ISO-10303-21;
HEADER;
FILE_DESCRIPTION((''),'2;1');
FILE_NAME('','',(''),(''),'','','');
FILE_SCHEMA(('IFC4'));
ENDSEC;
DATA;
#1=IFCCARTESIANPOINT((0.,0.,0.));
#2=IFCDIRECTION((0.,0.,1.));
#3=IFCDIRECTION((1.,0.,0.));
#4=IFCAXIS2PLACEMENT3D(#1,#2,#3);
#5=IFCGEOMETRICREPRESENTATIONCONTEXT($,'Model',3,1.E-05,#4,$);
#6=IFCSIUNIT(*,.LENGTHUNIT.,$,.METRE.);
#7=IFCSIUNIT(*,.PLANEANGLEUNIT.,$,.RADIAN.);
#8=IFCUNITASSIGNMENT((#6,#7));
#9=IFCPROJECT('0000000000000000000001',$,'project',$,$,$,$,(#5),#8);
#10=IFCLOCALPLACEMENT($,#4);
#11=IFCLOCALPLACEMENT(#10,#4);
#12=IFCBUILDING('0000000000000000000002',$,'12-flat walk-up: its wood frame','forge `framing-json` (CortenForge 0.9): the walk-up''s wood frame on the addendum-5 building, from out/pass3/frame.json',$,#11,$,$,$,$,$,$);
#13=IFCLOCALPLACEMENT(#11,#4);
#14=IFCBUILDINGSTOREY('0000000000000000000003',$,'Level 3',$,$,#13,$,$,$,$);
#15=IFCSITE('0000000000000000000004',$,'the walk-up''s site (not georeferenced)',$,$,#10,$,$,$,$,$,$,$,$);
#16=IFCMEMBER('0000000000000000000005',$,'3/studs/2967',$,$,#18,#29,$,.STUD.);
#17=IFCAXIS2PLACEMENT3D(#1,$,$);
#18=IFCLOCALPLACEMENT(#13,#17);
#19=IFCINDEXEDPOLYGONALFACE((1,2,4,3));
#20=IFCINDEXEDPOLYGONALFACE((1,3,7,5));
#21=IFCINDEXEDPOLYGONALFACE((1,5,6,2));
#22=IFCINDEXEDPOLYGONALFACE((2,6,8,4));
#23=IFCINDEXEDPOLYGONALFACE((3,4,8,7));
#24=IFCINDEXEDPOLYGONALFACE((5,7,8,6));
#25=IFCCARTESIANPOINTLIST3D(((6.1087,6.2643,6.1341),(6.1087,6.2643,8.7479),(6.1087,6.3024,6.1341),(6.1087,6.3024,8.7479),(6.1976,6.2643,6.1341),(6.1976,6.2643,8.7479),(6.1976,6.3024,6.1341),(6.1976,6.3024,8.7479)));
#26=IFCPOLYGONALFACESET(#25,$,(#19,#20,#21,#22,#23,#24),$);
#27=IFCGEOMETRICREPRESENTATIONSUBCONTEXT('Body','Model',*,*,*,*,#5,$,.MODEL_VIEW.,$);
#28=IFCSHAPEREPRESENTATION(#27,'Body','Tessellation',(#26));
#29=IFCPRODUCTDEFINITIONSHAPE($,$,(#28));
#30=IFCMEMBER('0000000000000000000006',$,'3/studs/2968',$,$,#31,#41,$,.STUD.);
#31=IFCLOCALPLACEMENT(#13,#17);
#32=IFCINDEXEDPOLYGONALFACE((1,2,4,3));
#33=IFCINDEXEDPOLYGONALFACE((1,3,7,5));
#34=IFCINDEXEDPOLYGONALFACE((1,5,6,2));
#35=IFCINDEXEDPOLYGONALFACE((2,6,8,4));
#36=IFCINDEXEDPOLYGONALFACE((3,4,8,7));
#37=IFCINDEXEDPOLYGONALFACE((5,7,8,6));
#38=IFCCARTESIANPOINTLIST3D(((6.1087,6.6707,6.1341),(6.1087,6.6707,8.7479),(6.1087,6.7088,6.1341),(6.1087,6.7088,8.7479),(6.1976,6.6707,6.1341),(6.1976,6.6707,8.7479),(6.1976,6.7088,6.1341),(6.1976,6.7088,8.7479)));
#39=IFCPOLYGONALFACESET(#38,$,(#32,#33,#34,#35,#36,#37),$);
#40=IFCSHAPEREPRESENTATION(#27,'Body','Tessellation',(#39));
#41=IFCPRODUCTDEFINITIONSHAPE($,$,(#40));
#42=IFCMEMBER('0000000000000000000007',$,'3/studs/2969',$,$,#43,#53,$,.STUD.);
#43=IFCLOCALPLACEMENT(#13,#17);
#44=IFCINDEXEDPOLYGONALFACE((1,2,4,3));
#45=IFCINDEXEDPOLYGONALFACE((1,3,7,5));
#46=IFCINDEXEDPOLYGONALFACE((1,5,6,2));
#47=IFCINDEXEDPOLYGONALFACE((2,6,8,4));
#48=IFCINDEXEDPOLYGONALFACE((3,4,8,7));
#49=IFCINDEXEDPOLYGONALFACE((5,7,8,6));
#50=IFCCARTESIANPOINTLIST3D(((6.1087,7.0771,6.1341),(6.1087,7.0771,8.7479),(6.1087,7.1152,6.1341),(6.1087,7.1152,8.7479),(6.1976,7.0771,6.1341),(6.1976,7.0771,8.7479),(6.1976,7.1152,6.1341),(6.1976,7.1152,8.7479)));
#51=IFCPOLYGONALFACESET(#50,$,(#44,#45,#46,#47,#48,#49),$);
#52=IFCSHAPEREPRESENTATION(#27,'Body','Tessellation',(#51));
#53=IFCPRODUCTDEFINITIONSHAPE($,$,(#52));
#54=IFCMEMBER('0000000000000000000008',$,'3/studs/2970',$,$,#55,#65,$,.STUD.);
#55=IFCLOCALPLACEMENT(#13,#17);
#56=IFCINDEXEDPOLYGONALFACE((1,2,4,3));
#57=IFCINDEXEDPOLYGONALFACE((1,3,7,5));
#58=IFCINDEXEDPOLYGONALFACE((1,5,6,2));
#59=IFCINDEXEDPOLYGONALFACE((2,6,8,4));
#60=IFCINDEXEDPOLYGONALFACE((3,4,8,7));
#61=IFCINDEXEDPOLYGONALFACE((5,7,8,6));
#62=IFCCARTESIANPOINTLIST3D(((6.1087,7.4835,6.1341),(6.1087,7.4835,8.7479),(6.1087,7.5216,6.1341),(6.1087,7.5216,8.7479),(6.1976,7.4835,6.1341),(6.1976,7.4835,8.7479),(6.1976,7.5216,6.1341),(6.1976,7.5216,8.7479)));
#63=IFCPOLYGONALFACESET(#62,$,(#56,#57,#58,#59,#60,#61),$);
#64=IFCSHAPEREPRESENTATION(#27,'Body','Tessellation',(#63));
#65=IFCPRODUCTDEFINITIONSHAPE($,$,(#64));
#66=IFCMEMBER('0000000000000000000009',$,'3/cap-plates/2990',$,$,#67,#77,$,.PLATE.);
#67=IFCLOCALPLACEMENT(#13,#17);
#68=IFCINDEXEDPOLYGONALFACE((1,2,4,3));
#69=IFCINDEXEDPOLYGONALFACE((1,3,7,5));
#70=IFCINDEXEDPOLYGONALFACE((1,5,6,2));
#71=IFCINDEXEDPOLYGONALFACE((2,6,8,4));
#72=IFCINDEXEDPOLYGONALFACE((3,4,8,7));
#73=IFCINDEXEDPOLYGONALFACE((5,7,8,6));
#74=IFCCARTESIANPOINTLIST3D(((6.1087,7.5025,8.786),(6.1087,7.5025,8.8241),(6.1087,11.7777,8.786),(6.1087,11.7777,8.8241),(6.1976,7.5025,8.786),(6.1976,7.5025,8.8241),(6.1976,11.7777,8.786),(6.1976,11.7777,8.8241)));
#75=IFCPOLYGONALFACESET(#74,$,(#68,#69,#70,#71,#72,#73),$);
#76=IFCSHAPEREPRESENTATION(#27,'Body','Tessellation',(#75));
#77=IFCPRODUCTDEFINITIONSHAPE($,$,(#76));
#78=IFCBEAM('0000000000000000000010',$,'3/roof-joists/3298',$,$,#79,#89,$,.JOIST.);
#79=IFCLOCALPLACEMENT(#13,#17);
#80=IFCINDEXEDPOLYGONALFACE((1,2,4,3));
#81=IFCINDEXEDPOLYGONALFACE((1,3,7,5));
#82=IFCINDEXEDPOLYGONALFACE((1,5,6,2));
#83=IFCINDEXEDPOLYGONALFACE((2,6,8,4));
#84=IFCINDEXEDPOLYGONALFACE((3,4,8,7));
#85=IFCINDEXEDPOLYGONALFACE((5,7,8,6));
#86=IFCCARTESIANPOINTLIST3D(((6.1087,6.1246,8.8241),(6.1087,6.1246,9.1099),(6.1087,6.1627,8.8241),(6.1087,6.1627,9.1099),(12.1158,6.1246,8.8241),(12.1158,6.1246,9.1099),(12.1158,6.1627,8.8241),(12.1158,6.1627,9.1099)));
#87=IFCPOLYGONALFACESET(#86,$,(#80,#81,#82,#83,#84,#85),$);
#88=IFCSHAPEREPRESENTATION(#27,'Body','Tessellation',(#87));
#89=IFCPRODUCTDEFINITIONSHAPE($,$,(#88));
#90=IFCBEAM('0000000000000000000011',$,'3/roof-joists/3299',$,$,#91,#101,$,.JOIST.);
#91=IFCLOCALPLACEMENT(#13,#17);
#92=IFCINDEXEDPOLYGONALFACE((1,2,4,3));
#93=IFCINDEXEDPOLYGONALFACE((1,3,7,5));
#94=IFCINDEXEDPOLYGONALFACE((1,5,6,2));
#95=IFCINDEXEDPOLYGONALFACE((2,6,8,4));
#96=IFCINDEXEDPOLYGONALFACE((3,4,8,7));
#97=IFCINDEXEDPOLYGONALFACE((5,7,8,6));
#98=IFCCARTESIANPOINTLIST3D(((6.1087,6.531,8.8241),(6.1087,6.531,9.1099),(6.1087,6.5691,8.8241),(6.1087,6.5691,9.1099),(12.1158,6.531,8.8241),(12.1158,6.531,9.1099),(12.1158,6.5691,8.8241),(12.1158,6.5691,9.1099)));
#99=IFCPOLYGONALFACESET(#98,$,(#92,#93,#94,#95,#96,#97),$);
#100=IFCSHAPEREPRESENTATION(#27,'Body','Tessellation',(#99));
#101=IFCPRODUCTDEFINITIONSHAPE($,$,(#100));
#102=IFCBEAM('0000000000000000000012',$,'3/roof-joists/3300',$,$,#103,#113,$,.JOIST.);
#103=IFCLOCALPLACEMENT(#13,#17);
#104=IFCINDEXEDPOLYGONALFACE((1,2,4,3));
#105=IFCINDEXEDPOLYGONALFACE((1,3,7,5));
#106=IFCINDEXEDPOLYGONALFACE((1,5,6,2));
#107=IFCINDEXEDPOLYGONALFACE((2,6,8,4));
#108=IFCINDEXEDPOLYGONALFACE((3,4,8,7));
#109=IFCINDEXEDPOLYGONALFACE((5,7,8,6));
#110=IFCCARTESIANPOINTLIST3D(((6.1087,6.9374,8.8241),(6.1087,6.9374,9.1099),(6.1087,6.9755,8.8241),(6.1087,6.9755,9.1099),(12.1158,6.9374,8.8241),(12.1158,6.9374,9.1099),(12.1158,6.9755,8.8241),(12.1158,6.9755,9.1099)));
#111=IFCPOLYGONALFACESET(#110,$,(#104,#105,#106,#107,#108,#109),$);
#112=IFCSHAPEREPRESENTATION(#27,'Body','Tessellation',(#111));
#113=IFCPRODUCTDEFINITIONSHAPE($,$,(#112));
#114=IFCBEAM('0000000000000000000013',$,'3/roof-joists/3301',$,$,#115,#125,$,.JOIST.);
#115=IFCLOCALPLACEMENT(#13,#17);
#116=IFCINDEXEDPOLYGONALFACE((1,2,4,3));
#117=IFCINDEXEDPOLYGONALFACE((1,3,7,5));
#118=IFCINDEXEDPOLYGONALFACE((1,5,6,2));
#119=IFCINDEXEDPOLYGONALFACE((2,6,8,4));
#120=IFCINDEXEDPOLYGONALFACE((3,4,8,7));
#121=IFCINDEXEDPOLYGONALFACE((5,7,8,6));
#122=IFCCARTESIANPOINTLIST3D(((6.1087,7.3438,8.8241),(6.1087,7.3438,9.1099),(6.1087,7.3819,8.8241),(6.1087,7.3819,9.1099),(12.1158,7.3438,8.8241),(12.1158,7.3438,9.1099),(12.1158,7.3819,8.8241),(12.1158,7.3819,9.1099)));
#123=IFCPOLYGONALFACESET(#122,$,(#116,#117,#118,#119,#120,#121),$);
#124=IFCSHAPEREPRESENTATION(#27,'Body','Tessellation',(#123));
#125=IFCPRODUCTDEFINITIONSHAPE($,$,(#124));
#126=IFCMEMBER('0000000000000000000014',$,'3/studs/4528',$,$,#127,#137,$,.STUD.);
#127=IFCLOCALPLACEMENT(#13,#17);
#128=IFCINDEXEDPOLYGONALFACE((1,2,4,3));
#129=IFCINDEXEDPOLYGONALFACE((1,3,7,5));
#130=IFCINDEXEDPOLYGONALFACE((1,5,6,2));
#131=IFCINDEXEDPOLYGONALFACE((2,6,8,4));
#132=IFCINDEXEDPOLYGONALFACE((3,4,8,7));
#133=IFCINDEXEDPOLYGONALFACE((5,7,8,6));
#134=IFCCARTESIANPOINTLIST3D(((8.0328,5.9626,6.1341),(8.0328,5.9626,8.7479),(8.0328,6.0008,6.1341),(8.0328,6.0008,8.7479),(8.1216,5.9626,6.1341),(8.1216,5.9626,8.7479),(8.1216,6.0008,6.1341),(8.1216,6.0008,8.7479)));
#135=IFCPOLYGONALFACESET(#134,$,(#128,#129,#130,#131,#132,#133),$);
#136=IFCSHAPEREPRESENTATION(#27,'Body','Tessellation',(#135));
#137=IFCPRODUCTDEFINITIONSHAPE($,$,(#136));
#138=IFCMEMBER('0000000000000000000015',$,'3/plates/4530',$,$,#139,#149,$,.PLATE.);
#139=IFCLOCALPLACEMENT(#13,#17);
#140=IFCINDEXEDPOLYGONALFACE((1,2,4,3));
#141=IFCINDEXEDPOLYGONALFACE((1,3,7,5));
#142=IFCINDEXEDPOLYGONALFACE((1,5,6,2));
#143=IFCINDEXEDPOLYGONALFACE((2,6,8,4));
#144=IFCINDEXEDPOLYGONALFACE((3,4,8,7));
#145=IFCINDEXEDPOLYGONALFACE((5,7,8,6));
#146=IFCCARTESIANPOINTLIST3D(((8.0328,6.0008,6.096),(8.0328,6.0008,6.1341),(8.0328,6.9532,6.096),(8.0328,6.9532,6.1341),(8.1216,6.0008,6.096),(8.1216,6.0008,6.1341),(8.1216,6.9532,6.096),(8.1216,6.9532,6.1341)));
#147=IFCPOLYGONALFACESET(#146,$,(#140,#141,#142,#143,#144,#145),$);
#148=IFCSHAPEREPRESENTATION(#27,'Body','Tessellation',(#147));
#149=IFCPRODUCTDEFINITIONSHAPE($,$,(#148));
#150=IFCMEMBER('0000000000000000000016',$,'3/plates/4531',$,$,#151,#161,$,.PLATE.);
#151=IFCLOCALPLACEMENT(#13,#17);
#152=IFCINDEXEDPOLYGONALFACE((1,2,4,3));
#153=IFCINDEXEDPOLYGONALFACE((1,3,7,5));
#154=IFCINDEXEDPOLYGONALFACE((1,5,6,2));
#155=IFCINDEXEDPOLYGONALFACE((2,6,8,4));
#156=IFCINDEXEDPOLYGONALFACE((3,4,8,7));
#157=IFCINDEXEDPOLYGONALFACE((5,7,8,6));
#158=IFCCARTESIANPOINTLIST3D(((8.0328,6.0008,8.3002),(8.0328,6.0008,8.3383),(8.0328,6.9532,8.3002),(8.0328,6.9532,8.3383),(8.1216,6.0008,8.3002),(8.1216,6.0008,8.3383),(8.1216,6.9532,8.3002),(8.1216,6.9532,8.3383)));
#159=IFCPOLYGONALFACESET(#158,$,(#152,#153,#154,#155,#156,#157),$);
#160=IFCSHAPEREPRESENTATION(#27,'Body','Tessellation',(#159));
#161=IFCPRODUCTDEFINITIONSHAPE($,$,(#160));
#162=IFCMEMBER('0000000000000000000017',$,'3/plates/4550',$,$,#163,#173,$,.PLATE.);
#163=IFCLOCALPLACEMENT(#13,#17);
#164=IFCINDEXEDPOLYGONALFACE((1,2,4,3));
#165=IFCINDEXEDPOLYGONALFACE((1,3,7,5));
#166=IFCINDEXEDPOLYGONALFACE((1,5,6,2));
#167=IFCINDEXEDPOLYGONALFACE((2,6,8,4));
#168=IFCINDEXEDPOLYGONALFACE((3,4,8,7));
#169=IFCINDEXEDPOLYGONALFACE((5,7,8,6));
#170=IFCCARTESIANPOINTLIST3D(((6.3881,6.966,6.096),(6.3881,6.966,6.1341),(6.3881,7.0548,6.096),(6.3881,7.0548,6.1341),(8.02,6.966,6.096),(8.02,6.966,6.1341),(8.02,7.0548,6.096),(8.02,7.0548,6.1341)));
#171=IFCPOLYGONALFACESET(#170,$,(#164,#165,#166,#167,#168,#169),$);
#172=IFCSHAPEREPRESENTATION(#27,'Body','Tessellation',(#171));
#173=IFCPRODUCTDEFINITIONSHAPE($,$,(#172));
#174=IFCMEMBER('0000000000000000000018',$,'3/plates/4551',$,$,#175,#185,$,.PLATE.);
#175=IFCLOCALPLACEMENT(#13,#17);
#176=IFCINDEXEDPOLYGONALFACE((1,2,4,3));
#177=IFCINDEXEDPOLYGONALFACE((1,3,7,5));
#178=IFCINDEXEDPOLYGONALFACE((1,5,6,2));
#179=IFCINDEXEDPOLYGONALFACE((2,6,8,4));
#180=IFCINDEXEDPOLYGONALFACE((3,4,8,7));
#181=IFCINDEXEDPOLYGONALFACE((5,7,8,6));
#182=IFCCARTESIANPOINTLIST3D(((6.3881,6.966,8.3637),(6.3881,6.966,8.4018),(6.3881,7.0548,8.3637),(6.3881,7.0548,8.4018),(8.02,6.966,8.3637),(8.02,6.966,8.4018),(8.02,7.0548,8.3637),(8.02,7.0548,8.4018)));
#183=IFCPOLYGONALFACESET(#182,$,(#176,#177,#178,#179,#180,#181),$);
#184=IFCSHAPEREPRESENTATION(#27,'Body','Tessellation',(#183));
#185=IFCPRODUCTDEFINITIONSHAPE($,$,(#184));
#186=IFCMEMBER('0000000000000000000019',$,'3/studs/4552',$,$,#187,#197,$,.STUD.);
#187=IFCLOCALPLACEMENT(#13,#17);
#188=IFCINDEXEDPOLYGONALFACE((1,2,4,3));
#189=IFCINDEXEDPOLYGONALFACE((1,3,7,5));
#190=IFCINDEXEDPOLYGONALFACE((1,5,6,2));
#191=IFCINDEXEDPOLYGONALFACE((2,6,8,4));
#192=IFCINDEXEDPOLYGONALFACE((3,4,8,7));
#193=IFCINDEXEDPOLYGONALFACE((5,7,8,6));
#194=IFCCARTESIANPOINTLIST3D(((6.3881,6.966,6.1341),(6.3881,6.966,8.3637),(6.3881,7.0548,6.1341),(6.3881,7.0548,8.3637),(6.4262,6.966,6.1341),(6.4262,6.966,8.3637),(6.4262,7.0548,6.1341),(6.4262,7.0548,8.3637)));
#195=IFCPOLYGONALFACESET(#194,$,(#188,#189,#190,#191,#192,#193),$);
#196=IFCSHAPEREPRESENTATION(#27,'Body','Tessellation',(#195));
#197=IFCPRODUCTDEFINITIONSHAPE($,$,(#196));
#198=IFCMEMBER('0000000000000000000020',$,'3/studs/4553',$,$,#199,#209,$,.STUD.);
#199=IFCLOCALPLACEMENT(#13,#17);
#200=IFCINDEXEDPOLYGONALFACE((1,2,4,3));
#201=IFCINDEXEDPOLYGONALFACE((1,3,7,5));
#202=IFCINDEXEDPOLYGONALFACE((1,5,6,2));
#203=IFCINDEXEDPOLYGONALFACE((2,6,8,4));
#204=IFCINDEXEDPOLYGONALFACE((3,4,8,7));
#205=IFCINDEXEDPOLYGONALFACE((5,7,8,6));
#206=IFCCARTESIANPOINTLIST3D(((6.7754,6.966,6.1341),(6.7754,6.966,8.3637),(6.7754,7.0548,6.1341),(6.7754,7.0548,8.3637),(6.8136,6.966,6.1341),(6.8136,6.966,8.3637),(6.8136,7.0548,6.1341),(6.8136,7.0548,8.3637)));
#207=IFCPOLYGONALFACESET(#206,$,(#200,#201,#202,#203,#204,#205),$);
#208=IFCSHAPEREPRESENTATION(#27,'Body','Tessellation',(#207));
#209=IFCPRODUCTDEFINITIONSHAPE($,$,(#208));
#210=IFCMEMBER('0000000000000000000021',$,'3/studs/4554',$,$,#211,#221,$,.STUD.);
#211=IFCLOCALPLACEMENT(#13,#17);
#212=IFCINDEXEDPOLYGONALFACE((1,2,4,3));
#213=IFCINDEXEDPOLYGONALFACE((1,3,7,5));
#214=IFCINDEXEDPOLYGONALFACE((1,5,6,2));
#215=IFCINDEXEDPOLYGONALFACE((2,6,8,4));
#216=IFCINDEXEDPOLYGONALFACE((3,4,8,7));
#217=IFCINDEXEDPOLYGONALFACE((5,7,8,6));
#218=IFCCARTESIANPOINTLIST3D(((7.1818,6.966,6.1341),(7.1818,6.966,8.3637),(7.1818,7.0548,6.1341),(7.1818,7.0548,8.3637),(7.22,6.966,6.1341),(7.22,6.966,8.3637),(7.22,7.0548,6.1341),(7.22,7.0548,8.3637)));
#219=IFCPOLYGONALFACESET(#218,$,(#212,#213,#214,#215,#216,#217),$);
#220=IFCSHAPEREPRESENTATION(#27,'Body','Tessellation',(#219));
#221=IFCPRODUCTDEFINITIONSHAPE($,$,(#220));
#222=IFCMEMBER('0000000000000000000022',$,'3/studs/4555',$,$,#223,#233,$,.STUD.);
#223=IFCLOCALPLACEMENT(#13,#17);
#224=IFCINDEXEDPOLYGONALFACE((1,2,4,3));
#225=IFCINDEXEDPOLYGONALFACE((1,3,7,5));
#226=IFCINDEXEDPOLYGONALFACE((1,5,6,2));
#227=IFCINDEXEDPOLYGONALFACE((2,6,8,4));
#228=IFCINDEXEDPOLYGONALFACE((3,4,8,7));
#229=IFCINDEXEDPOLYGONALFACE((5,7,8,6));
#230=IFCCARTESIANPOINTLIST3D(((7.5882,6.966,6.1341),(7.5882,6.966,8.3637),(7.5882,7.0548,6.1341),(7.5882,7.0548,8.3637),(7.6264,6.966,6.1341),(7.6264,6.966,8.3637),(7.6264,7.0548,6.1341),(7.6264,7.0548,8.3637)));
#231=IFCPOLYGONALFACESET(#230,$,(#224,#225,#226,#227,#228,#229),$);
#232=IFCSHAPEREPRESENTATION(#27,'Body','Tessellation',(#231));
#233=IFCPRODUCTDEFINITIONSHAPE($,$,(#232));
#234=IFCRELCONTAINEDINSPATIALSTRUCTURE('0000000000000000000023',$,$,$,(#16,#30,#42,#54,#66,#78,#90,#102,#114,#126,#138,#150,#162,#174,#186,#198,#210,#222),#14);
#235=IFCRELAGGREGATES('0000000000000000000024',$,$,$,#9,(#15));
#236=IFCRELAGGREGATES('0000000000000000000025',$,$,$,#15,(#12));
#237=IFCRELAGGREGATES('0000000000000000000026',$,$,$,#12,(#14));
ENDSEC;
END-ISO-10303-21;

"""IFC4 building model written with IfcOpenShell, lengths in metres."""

from ifc_helpers import new_model, si_unit, frame, frame_2d, origin, origin_with_axes, place, context, subcontext, project, spatial, rectangle, extrude, element, save


model = new_model("IFC4")

# Units and contexts
model_context = context("Model", 3, precision=1e-05, world=origin_with_axes())
body_context = subcontext(model_context, "Body", "Model", "MODEL_VIEW")
ifc_project = project(units=[si_unit("LENGTHUNIT", "METRE"), si_unit("PLANEANGLEUNIT", "RADIAN")], contexts=[model_context])

# Site, building, storey
site_placement = place(None, origin_with_axes())
site = spatial("IfcSite", under=ifc_project, at=site_placement, Name="the walk-up's site (not georeferenced)")
building_placement = place(site_placement, origin_with_axes())
building = spatial("IfcBuilding", under=site, at=building_placement, Name="12-flat walk-up: its wood frame", Description="forge `framing-json` (CortenForge 0.9): the walk-up's wood frame on the addendum-5 building, from out/pass3/frame.json")
storey_placement = place(building_placement, origin_with_axes())
storey = spatial("IfcBuildingStorey", under=building, at=storey_placement, Name="Level 3")

# Members
for number, where, z_axis, x_axis, name in (
    (1, (6.1087, 6.2643, 6.1341), (0.0, 0.0, 1.0), (1.0, 0.0, 0.0), "3/studs/2967"),
    (2, (6.1087, 6.6707, 6.1341), (0.0, 0.0, 1.0), (1.0, 0.0, 0.0), "3/studs/2968"),
    (3, (6.1087, 7.0771, 6.1341), (0.0, 0.0, 1.0), (1.0, 0.0, 0.0), "3/studs/2969"),
    (4, (6.1087, 7.4835, 6.1341), (0.0, 0.0, 1.0), (1.0, 0.0, 0.0), "3/studs/2970"),
):
    element("IfcMember", number, at=place(storey_placement, frame(where, z_axis=z_axis, x_axis=x_axis)), inside=storey, Name=name, PredefinedType="STUD", context=body_context, shape_type="SweptSolid", body=[
        extrude(rectangle(XDim=0.0889, YDim=0.0381, at=frame_2d((0.0445, 0.0191))), origin(), (0.0, 0.0, 1.0), 2.6138),
    ])
member_1_placement = place(storey_placement, frame((6.1087, 7.5025, 8.786), z_axis=(0.0, 0.0, 1.0), x_axis=(1.0, 0.0, 0.0)))
element("IfcMember", 5, at=member_1_placement, inside=storey, Name="3/cap-plates/2990", PredefinedType="PLATE", context=body_context, shape_type="SweptSolid", body=[
    extrude(rectangle(XDim=0.0889, YDim=4.2751, at=frame_2d((0.0445, 2.1376))), origin(), (0.0, 0.0, 1.0), 0.0381),
])

# Beams
for number, where, z_axis, x_axis, name in (
    (6, (6.1087, 6.1246, 8.8241), (0.0, 0.0, 1.0), (1.0, 0.0, 0.0), "3/roof-joists/3298"),
    (7, (6.1087, 6.531, 8.8241), (0.0, 0.0, 1.0), (1.0, 0.0, 0.0), "3/roof-joists/3299"),
    (8, (6.1087, 6.9374, 8.8241), (0.0, 0.0, 1.0), (1.0, 0.0, 0.0), "3/roof-joists/3300"),
    (9, (6.1087, 7.3438, 8.8241), (0.0, 0.0, 1.0), (1.0, 0.0, 0.0), "3/roof-joists/3301"),
):
    element("IfcBeam", number, at=place(storey_placement, frame(where, z_axis=z_axis, x_axis=x_axis)), inside=storey, Name=name, PredefinedType="JOIST", context=body_context, shape_type="SweptSolid", body=[
        extrude(rectangle(XDim=6.0071, YDim=0.0381, at=frame_2d((3.0036, 0.0191))), origin(), (0.0, 0.0, 1.0), 0.2858),
    ])

# Members
member_2_placement = place(storey_placement, frame((8.0328, 5.9627, 6.1341), z_axis=(0.0, 0.0, 1.0), x_axis=(1.0, 0.0, 0.0)))
element("IfcMember", 10, at=member_2_placement, inside=storey, Name="3/studs/4528", PredefinedType="STUD", context=body_context, shape_type="SweptSolid", body=[
    extrude(rectangle(XDim=0.0889, YDim=0.0381, at=frame_2d((0.0445, 0.0191))), origin(), (0.0, 0.0, 1.0), 2.6138),
])
for number, where, z_axis, x_axis, name in (
    (11, (8.0328, 6.0008, 6.096), (0.0, 0.0, 1.0), (1.0, 0.0, 0.0), "3/plates/4530"),
    (12, (8.0328, 6.0008, 8.3002), (0.0, 0.0, 1.0), (1.0, 0.0, 0.0), "3/plates/4531"),
):
    element("IfcMember", number, at=place(storey_placement, frame(where, z_axis=z_axis, x_axis=x_axis)), inside=storey, Name=name, PredefinedType="PLATE", context=body_context, shape_type="SweptSolid", body=[
        extrude(rectangle(XDim=0.0889, YDim=0.9525, at=frame_2d((0.0445, 0.4762))), origin(), (0.0, 0.0, 1.0), 0.0381),
    ])
for number, where, z_axis, x_axis, name in (
    (13, (6.3881, 6.966, 6.096), (0.0, 0.0, 1.0), (1.0, 0.0, 0.0), "3/plates/4550"),
    (14, (6.3881, 6.966, 8.3637), (0.0, 0.0, 1.0), (1.0, 0.0, 0.0), "3/plates/4551"),
):
    element("IfcMember", number, at=place(storey_placement, frame(where, z_axis=z_axis, x_axis=x_axis)), inside=storey, Name=name, PredefinedType="PLATE", context=body_context, shape_type="SweptSolid", body=[
        extrude(rectangle(XDim=1.6319, YDim=0.0889, at=frame_2d((0.816, 0.0444))), origin(), (0.0, 0.0, 1.0), 0.0381),
    ])
for number, where, z_axis, x_axis, name in (
    (15, (6.3881, 6.966, 6.1341), (0.0, 0.0, 1.0), (1.0, 0.0, 0.0), "3/studs/4552"),
    (16, (6.7755, 6.966, 6.1341), (0.0, 0.0, 1.0), (1.0, 0.0, 0.0), "3/studs/4553"),
    (17, (7.1818, 6.966, 6.1341), (0.0, 0.0, 1.0), (1.0, 0.0, 0.0), "3/studs/4554"),
    (18, (7.5883, 6.966, 6.1341), (0.0, 0.0, 1.0), (1.0, 0.0, 0.0), "3/studs/4555"),
):
    element("IfcMember", number, at=place(storey_placement, frame(where, z_axis=z_axis, x_axis=x_axis)), inside=storey, Name=name, PredefinedType="STUD", context=body_context, shape_type="SweptSolid", body=[
        extrude(rectangle(XDim=0.0381, YDim=0.0889, at=frame_2d((0.0191, 0.0444))), origin(), (0.0, 0.0, 1.0), 2.2296),
    ])

save(model, "model.ifc")
